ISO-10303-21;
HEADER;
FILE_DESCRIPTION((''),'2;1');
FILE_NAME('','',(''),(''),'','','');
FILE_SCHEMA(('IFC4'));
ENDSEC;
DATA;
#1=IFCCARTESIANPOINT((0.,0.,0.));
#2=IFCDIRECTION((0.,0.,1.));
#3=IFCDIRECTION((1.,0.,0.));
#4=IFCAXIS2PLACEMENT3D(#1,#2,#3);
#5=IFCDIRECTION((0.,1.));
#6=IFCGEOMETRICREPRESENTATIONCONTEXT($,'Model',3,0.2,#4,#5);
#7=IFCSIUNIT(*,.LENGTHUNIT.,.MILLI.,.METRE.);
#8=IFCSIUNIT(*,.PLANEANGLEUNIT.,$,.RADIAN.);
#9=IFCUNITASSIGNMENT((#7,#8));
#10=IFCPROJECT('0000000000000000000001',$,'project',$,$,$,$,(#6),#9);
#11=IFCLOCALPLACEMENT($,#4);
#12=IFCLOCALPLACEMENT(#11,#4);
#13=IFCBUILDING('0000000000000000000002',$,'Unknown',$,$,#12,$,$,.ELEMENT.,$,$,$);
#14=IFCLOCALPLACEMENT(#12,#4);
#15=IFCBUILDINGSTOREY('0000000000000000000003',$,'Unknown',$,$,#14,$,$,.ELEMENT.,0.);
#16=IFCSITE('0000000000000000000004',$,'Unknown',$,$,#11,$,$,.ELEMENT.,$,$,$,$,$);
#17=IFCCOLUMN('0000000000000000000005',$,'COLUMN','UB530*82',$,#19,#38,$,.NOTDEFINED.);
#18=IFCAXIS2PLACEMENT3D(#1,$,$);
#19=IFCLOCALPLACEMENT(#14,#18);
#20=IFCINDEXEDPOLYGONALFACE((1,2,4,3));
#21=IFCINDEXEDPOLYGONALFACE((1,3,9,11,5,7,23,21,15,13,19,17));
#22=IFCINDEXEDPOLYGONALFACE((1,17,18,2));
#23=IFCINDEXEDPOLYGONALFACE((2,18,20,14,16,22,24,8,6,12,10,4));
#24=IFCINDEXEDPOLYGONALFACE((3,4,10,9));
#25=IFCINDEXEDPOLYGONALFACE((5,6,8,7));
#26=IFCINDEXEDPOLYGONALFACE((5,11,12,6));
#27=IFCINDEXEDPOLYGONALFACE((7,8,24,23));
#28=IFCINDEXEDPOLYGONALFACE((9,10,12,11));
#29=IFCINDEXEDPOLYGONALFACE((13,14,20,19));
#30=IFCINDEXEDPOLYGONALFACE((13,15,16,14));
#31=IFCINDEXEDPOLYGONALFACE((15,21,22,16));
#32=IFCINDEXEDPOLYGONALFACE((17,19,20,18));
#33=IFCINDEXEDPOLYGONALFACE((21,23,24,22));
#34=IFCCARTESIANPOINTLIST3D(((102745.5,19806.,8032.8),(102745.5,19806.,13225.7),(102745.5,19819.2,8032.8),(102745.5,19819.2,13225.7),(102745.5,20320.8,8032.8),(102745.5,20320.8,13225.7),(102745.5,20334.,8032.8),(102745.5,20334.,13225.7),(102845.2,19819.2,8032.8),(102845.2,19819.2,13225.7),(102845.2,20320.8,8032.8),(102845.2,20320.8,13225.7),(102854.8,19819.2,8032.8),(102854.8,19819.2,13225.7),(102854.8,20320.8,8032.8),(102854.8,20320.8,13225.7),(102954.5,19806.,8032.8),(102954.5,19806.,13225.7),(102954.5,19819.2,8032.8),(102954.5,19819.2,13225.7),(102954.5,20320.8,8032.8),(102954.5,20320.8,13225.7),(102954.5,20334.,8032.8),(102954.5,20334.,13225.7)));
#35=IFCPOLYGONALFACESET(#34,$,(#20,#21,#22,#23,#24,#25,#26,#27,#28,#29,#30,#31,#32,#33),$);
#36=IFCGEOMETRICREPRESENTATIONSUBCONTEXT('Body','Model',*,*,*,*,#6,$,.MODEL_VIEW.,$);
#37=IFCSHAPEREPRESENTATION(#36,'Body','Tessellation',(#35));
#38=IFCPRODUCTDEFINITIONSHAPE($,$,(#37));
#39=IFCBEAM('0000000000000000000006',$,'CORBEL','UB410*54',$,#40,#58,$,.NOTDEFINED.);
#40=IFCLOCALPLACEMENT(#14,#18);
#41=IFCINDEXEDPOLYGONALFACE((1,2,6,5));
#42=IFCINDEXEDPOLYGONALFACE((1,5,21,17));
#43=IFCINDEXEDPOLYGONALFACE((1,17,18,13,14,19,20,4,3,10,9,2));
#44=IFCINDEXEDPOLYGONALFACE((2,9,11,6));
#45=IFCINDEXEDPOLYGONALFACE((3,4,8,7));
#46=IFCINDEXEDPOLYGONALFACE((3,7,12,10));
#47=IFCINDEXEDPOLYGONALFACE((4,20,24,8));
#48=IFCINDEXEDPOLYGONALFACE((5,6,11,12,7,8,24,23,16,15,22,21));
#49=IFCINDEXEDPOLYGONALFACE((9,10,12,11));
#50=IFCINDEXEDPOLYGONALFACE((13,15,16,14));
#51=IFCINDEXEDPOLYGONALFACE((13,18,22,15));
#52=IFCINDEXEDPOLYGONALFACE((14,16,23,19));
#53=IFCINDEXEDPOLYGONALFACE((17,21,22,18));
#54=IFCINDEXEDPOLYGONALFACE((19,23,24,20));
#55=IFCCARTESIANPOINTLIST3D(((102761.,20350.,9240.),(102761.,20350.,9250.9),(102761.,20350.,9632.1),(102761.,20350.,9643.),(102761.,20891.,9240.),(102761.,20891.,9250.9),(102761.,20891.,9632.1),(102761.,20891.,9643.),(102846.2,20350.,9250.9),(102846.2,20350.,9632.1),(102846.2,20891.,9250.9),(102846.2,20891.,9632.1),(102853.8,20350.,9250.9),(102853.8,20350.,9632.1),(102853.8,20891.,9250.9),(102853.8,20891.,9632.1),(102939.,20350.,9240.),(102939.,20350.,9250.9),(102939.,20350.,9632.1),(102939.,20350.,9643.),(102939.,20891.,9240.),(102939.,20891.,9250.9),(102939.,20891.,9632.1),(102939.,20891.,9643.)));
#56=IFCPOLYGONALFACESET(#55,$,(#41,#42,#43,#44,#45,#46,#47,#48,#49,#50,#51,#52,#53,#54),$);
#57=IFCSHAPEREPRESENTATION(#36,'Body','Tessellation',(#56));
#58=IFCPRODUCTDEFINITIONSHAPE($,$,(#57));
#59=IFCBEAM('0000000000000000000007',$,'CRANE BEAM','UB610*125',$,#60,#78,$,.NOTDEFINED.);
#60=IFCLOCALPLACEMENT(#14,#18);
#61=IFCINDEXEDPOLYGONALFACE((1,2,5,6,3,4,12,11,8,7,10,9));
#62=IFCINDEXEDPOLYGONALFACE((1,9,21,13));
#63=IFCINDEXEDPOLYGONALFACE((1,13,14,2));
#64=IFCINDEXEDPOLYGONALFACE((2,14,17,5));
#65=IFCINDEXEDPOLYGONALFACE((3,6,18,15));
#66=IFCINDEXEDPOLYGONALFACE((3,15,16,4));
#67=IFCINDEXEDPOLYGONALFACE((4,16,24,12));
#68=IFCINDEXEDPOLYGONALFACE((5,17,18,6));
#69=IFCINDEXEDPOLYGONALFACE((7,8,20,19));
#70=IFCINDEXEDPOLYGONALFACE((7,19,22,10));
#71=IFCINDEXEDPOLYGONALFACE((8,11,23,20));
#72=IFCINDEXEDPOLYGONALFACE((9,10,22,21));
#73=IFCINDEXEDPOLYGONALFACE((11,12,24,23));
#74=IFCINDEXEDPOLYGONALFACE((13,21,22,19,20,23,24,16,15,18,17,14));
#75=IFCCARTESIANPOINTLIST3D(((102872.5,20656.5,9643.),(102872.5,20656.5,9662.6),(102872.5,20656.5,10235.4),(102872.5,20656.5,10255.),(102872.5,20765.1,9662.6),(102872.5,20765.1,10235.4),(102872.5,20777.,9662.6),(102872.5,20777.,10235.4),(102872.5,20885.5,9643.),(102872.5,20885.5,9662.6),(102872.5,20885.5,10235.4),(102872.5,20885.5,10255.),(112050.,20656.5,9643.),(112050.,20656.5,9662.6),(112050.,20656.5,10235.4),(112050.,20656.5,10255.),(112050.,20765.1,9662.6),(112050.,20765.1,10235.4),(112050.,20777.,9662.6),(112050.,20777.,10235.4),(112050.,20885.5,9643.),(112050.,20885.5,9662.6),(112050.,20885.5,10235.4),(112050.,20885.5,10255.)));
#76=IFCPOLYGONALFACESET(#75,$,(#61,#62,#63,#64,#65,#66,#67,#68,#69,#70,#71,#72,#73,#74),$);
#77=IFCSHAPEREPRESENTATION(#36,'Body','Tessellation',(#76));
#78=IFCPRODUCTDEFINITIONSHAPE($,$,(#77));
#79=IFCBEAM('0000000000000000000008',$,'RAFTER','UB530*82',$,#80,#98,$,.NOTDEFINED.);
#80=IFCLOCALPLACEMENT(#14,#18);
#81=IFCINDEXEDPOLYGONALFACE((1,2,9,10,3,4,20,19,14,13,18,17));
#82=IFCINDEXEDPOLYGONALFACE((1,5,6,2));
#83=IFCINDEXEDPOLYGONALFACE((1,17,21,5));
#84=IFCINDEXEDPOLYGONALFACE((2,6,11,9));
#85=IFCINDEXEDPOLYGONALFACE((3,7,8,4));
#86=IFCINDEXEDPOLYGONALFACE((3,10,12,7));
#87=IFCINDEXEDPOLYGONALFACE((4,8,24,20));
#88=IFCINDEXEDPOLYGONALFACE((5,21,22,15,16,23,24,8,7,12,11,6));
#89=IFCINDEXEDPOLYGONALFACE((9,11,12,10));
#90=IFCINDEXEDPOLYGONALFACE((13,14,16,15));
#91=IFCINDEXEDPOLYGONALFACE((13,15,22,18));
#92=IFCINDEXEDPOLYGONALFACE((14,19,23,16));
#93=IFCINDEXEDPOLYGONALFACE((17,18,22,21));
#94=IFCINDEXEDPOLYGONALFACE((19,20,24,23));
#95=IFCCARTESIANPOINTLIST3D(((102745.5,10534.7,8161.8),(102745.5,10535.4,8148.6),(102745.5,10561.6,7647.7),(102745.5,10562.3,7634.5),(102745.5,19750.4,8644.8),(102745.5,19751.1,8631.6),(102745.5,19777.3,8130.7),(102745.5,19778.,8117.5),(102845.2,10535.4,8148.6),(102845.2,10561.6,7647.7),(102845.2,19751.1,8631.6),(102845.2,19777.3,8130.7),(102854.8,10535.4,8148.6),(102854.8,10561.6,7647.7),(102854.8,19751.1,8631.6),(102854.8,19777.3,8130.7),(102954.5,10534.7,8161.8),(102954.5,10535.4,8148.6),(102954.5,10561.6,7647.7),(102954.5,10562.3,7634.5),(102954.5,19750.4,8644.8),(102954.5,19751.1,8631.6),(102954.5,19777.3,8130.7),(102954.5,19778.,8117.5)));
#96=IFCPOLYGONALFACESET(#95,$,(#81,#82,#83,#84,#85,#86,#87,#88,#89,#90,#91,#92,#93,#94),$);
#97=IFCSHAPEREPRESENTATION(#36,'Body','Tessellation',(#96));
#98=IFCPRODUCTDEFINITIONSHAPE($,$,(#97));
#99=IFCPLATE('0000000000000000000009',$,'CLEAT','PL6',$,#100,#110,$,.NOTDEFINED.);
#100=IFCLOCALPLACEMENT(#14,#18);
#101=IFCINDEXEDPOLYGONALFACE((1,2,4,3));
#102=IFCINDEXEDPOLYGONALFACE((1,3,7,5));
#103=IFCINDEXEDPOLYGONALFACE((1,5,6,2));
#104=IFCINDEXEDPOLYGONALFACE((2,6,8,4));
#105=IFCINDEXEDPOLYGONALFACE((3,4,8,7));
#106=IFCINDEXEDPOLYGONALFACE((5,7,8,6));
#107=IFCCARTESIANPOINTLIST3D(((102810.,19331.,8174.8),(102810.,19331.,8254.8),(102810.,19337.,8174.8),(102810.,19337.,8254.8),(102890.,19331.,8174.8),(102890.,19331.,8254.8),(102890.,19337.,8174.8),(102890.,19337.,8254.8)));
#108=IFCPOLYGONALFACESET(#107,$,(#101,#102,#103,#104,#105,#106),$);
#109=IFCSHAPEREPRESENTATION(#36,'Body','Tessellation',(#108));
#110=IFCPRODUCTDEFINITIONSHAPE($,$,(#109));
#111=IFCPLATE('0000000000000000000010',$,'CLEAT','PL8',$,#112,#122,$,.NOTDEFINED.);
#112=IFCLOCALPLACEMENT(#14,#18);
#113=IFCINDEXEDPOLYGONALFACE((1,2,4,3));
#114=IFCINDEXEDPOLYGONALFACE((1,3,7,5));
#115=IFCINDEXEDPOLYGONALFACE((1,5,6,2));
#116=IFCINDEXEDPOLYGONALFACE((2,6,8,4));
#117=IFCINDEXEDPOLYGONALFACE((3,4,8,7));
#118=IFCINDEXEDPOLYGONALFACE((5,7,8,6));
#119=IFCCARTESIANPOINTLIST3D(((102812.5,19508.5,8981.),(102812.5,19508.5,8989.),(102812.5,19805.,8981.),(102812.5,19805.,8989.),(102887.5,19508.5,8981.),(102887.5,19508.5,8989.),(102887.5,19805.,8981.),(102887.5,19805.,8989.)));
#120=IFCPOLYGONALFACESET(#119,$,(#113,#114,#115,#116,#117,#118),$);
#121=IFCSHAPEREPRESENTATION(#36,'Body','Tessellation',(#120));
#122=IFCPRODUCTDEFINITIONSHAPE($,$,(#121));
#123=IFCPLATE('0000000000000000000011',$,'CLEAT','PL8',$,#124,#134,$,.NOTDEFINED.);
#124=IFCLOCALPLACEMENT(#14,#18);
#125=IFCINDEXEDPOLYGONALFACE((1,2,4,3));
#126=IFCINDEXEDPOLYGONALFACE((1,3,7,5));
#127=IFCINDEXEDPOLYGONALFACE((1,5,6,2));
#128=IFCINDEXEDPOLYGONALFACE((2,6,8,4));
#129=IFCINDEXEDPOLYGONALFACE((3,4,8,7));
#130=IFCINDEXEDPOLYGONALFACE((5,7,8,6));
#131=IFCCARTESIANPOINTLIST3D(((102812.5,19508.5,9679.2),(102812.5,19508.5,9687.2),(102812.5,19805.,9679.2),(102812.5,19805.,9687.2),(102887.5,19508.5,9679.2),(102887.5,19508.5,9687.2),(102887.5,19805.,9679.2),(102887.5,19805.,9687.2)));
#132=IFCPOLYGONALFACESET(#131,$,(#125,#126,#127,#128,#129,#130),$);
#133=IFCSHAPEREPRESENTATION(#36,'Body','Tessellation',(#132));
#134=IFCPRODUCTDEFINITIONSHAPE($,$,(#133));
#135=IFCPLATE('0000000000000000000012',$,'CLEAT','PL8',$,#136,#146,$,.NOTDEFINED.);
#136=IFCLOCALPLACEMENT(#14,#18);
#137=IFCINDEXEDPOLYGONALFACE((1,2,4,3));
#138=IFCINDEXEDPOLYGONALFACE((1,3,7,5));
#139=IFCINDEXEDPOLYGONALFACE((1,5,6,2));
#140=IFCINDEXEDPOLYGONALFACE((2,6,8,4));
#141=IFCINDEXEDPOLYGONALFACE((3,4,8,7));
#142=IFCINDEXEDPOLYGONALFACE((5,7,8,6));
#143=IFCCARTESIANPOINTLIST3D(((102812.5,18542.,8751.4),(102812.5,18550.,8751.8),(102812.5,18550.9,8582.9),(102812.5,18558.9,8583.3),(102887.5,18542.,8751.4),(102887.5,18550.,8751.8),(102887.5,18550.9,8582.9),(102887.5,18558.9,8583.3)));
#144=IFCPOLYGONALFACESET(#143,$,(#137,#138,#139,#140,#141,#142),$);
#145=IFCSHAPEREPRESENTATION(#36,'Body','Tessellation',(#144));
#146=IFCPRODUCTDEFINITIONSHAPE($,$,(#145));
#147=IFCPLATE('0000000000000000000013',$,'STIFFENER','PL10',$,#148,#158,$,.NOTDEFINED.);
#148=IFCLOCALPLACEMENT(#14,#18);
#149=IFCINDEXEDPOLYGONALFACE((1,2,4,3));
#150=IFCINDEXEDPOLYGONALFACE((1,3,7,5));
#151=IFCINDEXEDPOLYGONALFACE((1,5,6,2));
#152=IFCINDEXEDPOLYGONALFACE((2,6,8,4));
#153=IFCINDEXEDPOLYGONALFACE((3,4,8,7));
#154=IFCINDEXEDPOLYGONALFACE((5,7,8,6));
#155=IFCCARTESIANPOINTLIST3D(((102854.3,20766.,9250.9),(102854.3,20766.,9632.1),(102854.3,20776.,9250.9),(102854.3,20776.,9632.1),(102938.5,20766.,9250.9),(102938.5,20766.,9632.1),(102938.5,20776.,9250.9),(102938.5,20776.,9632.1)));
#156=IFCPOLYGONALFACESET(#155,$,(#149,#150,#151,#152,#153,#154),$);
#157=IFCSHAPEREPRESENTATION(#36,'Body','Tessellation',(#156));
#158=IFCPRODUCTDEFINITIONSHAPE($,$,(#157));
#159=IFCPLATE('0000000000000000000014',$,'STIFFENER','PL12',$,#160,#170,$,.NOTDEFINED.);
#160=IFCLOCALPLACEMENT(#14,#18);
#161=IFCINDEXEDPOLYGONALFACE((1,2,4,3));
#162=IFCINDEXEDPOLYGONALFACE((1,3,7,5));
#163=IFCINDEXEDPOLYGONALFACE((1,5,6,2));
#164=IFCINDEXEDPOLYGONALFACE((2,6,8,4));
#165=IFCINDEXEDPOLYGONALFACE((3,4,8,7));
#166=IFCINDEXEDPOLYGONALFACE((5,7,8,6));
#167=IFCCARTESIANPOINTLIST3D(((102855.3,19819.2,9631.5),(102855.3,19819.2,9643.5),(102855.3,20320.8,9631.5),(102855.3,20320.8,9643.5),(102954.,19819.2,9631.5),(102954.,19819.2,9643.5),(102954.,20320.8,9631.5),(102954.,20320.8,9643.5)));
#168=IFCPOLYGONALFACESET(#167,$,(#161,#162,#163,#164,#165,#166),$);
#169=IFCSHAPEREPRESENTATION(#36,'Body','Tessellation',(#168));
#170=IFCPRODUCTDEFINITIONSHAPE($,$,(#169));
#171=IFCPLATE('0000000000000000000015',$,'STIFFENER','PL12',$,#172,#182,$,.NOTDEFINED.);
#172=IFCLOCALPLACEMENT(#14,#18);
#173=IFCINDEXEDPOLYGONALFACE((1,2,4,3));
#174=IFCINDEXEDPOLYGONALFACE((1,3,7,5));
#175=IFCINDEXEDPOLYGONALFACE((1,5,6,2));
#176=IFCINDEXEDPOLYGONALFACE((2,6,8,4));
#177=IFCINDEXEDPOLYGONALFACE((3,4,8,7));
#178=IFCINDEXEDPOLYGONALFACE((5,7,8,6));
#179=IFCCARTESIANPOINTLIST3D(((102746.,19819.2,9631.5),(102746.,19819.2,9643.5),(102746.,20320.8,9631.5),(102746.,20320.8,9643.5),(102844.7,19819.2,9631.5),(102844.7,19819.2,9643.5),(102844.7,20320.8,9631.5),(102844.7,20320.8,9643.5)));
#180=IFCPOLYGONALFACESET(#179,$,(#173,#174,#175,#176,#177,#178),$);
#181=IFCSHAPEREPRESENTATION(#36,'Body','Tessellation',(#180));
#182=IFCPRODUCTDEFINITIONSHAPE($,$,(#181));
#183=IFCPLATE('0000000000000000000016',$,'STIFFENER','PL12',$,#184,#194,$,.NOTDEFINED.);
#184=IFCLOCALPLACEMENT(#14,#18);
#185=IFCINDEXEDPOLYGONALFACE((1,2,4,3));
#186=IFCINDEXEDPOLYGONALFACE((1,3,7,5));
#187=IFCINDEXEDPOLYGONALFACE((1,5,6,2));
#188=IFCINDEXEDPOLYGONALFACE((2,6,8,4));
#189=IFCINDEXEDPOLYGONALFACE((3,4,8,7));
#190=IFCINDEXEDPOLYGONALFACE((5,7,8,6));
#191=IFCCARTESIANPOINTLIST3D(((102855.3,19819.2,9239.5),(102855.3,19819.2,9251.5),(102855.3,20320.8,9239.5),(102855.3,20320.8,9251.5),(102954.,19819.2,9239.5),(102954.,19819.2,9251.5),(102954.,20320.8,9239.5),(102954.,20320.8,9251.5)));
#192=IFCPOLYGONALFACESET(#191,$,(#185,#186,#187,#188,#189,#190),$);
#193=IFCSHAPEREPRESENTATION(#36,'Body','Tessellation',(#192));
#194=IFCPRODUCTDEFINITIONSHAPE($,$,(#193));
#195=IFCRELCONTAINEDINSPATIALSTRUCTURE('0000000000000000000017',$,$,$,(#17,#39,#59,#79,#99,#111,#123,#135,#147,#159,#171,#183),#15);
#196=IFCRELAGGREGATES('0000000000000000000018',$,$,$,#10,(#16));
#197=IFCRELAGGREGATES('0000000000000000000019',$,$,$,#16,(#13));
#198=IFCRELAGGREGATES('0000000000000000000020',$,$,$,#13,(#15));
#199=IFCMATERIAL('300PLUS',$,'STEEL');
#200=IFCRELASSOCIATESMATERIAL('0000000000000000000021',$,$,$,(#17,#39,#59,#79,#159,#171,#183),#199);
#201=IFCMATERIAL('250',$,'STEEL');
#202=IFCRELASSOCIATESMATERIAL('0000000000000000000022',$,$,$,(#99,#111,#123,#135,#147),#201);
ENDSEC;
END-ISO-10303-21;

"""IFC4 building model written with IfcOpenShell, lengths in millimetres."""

from ifc_helpers import new_model, si_unit, direction, frame, origin_with_axes, place, context, subcontext, project, spatial, line, indexed_curve, outline, extrude, material, element, save


model = new_model("IFC4")

# Units and contexts
model_context = context("Model", 3, precision=0.2, world=origin_with_axes(), true_north=direction((0.0, 1.0)))
body_context = subcontext(model_context, "Body", "Model", "MODEL_VIEW")
ifc_project = project(units=[si_unit("LENGTHUNIT", "METRE", prefix="MILLI"), si_unit("PLANEANGLEUNIT", "RADIAN")], contexts=[model_context])

# Site, building, storey
site_placement = place(None, origin_with_axes())
site = spatial("IfcSite", under=ifc_project, at=site_placement, Name="Unknown", CompositionType="ELEMENT")
building_placement = place(site_placement, origin_with_axes())
building = spatial("IfcBuilding", under=site, at=building_placement, Name="Unknown", CompositionType="ELEMENT")
storey_placement = place(building_placement, origin_with_axes())
storey = spatial("IfcBuildingStorey", under=building, at=storey_placement, Name="Unknown", CompositionType="ELEMENT", Elevation=0.0)

# Column
ifc_material_1 = material(Name="300PLUS", Category="STEEL")
column_placement = place(storey_placement, frame((102850.0, 20070.0, 8032.8), z_axis=(-1.0, 0.0, 0.0), x_axis=(0.0, 0.0, 1.0)))
element("IfcColumn", 1, at=column_placement, inside=storey, material=ifc_material_1, Name="COLUMN", Description="UB530*82", PredefinedType="NOTDEFINED", context=body_context, shape_type="SolidModel", body=[
    extrude(outline(indexed_curve([(-104.5, -264.0), (104.5, -264.0), (104.5, -250.8), (4.8, -250.8), (4.8, 250.8), (104.5, 250.8), (104.5, 264.0), (-104.5, 264.0), (-104.5, 250.8), (-4.8, 250.8), (-4.8, -250.8), (-104.5, -250.8)], segments=[line(1, 2, 3, 4, 5, 6, 7, 8, 9, 10, 11, 12, 1)])), frame((0.0, 0.0, 0.0), z_axis=(-1.0, 0.0, 0.0), x_axis=(0.0, 0.0, 1.0)), (0.0, 0.0, -1.0), 5192.9),
])

# Beams
beam_1_placement = place(storey_placement, frame((102850.0, 20350.0, 9441.5), z_axis=(1.0, 0.0, 0.0), x_axis=(0.0, 1.0, 0.0)))
element("IfcBeam", 2, at=beam_1_placement, inside=storey, material=ifc_material_1, Name="CORBEL", Description="UB410*54", PredefinedType="NOTDEFINED", context=body_context, shape_type="SolidModel", body=[
    extrude(outline(indexed_curve([(-89.0, -201.5), (89.0, -201.5), (89.0, -190.6), (3.8, -190.6), (3.8, 190.6), (89.0, 190.6), (89.0, 201.5), (-89.0, 201.5), (-89.0, 190.6), (-3.8, 190.6), (-3.8, -190.6), (-89.0, -190.6)], segments=[line(1, 2, 3, 4, 5, 6, 7, 8, 9, 10, 11, 12, 1)])), frame((0.0, 0.0, 0.0), z_axis=(-1.0, 0.0, 0.0), x_axis=(0.0, 0.0, 1.0)), (0.0, 0.0, -1.0), 541.0),
])
beam_2_placement = place(storey_placement, frame((102872.5, 20771.0, 9949.0), z_axis=(0.0, -1.0, 0.0), x_axis=(1.0, 0.0, 0.0)))
element("IfcBeam", 3, at=beam_2_placement, inside=storey, material=ifc_material_1, Name="CRANE BEAM", Description="UB610*125", PredefinedType="NOTDEFINED", context=body_context, shape_type="SolidModel", body=[
    extrude(outline(indexed_curve([(-114.5, -306.0), (114.5, -306.0), (114.5, -286.4), (6.0, -286.4), (6.0, 286.4), (114.5, 286.4), (114.5, 306.0), (-114.5, 306.0), (-114.5, 286.4), (-6.0, 286.4), (-6.0, -286.4), (-114.5, -286.4)], segments=[line(1, 2, 3, 4, 5, 6, 7, 8, 9, 10, 11, 12, 1)])), frame((0.0, 0.0, 0.0), z_axis=(-1.0, 0.0, 0.0), x_axis=(0.0, 0.0, 1.0)), (0.0, 0.0, -1.0), 9177.5),
])
beam_3_placement = place(storey_placement, frame((102850.0, 19764.2, 8381.2), z_axis=(-1.0, 0.0, 0.0), x_axis=(0.0, -0.998629, -0.052339)))
element("IfcBeam", 4, at=beam_3_placement, inside=storey, material=ifc_material_1, Name="RAFTER", Description="UB530*82", PredefinedType="NOTDEFINED", context=body_context, shape_type="SolidModel", body=[
    extrude(outline(indexed_curve([(-104.5, -264.0), (104.5, -264.0), (104.5, -250.8), (4.8, -250.8), (4.8, 250.8), (104.5, 250.8), (104.5, 264.0), (-104.5, 264.0), (-104.5, 250.8), (-4.8, 250.8), (-4.8, -250.8), (-104.5, -250.8)], segments=[line(1, 2, 3, 4, 5, 6, 7, 8, 9, 10, 11, 12, 1)])), frame((0.0, 0.0, 0.0), z_axis=(-1.0, 0.0, 0.0), x_axis=(0.0, 0.0, 1.0)), (0.0, 0.0, -1.0), 9228.3),
])

# Plates
ifc_material_2 = material(Name="250", Category="STEEL")
plate_1_placement = place(storey_placement, frame((102890.0, 19334.0, 8174.8), z_axis=(0.0, 1.0, 0.0), x_axis=(-1.0, 0.0, 0.0)))
element("IfcPlate", 5, at=plate_1_placement, inside=storey, material=ifc_material_2, Name="CLEAT", Description="PL6", PredefinedType="NOTDEFINED", context=body_context, shape_type="SolidModel", body=[
    extrude(outline(indexed_curve([(0.0, 0.0), (80.0, 0.0), (80.0, 80.0), (0.0, 80.0)], segments=[line(1, 2, 3, 4, 1)])), frame((0.0, 0.0, 3.0), z_axis=(0.0, 0.0, 1.0), x_axis=(1.0, 0.0, 0.0)), (0.0, 0.0, -1.0), 6.0),
])
for number, where, z_axis, x_axis, name in (
    (6, (102812.5, 19508.5, 8985.0), (0.0, 0.0, 1.0), (1.0, 0.0, 0.0), "CLEAT"),
    (7, (102812.5, 19508.5, 9683.2), (0.0, 0.0, 1.0), (1.0, 0.0, 0.0), "CLEAT"),
):
    element("IfcPlate", number, at=place(storey_placement, frame(where, z_axis=z_axis, x_axis=x_axis)), inside=storey, material=ifc_material_2, Name=name, Description="PL8", PredefinedType="NOTDEFINED", context=body_context, shape_type="SolidModel", body=[
        extrude(outline(indexed_curve([(0.0, 0.0), (75.0, 0.0), (75.0, 296.5), (0.0, 296.5)], segments=[line(1, 2, 3, 4, 1)])), frame((0.0, 0.0, 4.0), z_axis=(0.0, 0.0, 1.0), x_axis=(1.0, 0.0, 0.0)), (0.0, 0.0, -1.0), 8.0),
    ])
plate_2_placement = place(storey_placement, frame((102812.5, 18546.0, 8751.6), z_axis=(0.0, 0.998608, 0.052745), x_axis=(1.0, 0.0, 0.0)))
element("IfcPlate", 8, at=plate_2_placement, inside=storey, material=ifc_material_2, Name="CLEAT", Description="PL8", PredefinedType="NOTDEFINED", context=body_context, shape_type="SolidModel", body=[
    extrude(outline(indexed_curve([(0.0, 0.0), (75.0, 0.0), (75.0, 168.7), (0.0, 168.7)], segments=[line(1, 2, 3, 4, 1)])), frame((0.0, 0.0, 4.0), z_axis=(0.0, 0.0, 1.0), x_axis=(1.0, 0.0, 0.0)), (0.0, 0.0, -1.0), 8.0),
])
plate_3_placement = place(storey_placement, frame((102854.3, 20771.0, 9632.1), z_axis=(0.0, 1.0, 0.0), x_axis=(1.0, 0.0, 0.0)))
element("IfcPlate", 9, at=plate_3_placement, inside=storey, material=ifc_material_2, Name="STIFFENER", Description="PL10", PredefinedType="NOTDEFINED", context=body_context, shape_type="SolidModel", body=[
    extrude(outline(indexed_curve([(0.0, 0.0), (84.2, 0.0), (84.2, 381.2), (0.0, 381.2)], segments=[line(1, 2, 3, 4, 1)])), frame((0.0, 0.0, 5.0), z_axis=(0.0, 0.0, 1.0), x_axis=(1.0, 0.0, 0.0)), (0.0, 0.0, -1.0), 10.0),
])
for number, where, z_axis, x_axis, name in (
    (10, (102954.0, 19819.2, 9637.5), (0.0, 0.0, 1.0), (0.0, 1.0, 0.0), "STIFFENER"),
    (11, (102844.7, 19819.2, 9637.5), (0.0, 0.0, 1.0), (0.0, 1.0, 0.0), "STIFFENER"),
    (12, (102954.0, 19819.2, 9245.5), (0.0, 0.0, 1.0), (0.0, 1.0, 0.0), "STIFFENER"),
):
    element("IfcPlate", number, at=place(storey_placement, frame(where, z_axis=z_axis, x_axis=x_axis)), inside=storey, material=ifc_material_1, Name=name, Description="PL12", PredefinedType="NOTDEFINED", context=body_context, shape_type="SolidModel", body=[
        extrude(outline(indexed_curve([(0.0, 0.0), (501.6, 0.0), (501.6, 98.7), (0.0, 98.7)], segments=[line(1, 2, 3, 4, 1)])), frame((0.0, 0.0, 6.0), z_axis=(0.0, 0.0, 1.0), x_axis=(1.0, 0.0, 0.0)), (0.0, 0.0, -1.0), 12.0),
    ])

save(model, "model.ifc")
